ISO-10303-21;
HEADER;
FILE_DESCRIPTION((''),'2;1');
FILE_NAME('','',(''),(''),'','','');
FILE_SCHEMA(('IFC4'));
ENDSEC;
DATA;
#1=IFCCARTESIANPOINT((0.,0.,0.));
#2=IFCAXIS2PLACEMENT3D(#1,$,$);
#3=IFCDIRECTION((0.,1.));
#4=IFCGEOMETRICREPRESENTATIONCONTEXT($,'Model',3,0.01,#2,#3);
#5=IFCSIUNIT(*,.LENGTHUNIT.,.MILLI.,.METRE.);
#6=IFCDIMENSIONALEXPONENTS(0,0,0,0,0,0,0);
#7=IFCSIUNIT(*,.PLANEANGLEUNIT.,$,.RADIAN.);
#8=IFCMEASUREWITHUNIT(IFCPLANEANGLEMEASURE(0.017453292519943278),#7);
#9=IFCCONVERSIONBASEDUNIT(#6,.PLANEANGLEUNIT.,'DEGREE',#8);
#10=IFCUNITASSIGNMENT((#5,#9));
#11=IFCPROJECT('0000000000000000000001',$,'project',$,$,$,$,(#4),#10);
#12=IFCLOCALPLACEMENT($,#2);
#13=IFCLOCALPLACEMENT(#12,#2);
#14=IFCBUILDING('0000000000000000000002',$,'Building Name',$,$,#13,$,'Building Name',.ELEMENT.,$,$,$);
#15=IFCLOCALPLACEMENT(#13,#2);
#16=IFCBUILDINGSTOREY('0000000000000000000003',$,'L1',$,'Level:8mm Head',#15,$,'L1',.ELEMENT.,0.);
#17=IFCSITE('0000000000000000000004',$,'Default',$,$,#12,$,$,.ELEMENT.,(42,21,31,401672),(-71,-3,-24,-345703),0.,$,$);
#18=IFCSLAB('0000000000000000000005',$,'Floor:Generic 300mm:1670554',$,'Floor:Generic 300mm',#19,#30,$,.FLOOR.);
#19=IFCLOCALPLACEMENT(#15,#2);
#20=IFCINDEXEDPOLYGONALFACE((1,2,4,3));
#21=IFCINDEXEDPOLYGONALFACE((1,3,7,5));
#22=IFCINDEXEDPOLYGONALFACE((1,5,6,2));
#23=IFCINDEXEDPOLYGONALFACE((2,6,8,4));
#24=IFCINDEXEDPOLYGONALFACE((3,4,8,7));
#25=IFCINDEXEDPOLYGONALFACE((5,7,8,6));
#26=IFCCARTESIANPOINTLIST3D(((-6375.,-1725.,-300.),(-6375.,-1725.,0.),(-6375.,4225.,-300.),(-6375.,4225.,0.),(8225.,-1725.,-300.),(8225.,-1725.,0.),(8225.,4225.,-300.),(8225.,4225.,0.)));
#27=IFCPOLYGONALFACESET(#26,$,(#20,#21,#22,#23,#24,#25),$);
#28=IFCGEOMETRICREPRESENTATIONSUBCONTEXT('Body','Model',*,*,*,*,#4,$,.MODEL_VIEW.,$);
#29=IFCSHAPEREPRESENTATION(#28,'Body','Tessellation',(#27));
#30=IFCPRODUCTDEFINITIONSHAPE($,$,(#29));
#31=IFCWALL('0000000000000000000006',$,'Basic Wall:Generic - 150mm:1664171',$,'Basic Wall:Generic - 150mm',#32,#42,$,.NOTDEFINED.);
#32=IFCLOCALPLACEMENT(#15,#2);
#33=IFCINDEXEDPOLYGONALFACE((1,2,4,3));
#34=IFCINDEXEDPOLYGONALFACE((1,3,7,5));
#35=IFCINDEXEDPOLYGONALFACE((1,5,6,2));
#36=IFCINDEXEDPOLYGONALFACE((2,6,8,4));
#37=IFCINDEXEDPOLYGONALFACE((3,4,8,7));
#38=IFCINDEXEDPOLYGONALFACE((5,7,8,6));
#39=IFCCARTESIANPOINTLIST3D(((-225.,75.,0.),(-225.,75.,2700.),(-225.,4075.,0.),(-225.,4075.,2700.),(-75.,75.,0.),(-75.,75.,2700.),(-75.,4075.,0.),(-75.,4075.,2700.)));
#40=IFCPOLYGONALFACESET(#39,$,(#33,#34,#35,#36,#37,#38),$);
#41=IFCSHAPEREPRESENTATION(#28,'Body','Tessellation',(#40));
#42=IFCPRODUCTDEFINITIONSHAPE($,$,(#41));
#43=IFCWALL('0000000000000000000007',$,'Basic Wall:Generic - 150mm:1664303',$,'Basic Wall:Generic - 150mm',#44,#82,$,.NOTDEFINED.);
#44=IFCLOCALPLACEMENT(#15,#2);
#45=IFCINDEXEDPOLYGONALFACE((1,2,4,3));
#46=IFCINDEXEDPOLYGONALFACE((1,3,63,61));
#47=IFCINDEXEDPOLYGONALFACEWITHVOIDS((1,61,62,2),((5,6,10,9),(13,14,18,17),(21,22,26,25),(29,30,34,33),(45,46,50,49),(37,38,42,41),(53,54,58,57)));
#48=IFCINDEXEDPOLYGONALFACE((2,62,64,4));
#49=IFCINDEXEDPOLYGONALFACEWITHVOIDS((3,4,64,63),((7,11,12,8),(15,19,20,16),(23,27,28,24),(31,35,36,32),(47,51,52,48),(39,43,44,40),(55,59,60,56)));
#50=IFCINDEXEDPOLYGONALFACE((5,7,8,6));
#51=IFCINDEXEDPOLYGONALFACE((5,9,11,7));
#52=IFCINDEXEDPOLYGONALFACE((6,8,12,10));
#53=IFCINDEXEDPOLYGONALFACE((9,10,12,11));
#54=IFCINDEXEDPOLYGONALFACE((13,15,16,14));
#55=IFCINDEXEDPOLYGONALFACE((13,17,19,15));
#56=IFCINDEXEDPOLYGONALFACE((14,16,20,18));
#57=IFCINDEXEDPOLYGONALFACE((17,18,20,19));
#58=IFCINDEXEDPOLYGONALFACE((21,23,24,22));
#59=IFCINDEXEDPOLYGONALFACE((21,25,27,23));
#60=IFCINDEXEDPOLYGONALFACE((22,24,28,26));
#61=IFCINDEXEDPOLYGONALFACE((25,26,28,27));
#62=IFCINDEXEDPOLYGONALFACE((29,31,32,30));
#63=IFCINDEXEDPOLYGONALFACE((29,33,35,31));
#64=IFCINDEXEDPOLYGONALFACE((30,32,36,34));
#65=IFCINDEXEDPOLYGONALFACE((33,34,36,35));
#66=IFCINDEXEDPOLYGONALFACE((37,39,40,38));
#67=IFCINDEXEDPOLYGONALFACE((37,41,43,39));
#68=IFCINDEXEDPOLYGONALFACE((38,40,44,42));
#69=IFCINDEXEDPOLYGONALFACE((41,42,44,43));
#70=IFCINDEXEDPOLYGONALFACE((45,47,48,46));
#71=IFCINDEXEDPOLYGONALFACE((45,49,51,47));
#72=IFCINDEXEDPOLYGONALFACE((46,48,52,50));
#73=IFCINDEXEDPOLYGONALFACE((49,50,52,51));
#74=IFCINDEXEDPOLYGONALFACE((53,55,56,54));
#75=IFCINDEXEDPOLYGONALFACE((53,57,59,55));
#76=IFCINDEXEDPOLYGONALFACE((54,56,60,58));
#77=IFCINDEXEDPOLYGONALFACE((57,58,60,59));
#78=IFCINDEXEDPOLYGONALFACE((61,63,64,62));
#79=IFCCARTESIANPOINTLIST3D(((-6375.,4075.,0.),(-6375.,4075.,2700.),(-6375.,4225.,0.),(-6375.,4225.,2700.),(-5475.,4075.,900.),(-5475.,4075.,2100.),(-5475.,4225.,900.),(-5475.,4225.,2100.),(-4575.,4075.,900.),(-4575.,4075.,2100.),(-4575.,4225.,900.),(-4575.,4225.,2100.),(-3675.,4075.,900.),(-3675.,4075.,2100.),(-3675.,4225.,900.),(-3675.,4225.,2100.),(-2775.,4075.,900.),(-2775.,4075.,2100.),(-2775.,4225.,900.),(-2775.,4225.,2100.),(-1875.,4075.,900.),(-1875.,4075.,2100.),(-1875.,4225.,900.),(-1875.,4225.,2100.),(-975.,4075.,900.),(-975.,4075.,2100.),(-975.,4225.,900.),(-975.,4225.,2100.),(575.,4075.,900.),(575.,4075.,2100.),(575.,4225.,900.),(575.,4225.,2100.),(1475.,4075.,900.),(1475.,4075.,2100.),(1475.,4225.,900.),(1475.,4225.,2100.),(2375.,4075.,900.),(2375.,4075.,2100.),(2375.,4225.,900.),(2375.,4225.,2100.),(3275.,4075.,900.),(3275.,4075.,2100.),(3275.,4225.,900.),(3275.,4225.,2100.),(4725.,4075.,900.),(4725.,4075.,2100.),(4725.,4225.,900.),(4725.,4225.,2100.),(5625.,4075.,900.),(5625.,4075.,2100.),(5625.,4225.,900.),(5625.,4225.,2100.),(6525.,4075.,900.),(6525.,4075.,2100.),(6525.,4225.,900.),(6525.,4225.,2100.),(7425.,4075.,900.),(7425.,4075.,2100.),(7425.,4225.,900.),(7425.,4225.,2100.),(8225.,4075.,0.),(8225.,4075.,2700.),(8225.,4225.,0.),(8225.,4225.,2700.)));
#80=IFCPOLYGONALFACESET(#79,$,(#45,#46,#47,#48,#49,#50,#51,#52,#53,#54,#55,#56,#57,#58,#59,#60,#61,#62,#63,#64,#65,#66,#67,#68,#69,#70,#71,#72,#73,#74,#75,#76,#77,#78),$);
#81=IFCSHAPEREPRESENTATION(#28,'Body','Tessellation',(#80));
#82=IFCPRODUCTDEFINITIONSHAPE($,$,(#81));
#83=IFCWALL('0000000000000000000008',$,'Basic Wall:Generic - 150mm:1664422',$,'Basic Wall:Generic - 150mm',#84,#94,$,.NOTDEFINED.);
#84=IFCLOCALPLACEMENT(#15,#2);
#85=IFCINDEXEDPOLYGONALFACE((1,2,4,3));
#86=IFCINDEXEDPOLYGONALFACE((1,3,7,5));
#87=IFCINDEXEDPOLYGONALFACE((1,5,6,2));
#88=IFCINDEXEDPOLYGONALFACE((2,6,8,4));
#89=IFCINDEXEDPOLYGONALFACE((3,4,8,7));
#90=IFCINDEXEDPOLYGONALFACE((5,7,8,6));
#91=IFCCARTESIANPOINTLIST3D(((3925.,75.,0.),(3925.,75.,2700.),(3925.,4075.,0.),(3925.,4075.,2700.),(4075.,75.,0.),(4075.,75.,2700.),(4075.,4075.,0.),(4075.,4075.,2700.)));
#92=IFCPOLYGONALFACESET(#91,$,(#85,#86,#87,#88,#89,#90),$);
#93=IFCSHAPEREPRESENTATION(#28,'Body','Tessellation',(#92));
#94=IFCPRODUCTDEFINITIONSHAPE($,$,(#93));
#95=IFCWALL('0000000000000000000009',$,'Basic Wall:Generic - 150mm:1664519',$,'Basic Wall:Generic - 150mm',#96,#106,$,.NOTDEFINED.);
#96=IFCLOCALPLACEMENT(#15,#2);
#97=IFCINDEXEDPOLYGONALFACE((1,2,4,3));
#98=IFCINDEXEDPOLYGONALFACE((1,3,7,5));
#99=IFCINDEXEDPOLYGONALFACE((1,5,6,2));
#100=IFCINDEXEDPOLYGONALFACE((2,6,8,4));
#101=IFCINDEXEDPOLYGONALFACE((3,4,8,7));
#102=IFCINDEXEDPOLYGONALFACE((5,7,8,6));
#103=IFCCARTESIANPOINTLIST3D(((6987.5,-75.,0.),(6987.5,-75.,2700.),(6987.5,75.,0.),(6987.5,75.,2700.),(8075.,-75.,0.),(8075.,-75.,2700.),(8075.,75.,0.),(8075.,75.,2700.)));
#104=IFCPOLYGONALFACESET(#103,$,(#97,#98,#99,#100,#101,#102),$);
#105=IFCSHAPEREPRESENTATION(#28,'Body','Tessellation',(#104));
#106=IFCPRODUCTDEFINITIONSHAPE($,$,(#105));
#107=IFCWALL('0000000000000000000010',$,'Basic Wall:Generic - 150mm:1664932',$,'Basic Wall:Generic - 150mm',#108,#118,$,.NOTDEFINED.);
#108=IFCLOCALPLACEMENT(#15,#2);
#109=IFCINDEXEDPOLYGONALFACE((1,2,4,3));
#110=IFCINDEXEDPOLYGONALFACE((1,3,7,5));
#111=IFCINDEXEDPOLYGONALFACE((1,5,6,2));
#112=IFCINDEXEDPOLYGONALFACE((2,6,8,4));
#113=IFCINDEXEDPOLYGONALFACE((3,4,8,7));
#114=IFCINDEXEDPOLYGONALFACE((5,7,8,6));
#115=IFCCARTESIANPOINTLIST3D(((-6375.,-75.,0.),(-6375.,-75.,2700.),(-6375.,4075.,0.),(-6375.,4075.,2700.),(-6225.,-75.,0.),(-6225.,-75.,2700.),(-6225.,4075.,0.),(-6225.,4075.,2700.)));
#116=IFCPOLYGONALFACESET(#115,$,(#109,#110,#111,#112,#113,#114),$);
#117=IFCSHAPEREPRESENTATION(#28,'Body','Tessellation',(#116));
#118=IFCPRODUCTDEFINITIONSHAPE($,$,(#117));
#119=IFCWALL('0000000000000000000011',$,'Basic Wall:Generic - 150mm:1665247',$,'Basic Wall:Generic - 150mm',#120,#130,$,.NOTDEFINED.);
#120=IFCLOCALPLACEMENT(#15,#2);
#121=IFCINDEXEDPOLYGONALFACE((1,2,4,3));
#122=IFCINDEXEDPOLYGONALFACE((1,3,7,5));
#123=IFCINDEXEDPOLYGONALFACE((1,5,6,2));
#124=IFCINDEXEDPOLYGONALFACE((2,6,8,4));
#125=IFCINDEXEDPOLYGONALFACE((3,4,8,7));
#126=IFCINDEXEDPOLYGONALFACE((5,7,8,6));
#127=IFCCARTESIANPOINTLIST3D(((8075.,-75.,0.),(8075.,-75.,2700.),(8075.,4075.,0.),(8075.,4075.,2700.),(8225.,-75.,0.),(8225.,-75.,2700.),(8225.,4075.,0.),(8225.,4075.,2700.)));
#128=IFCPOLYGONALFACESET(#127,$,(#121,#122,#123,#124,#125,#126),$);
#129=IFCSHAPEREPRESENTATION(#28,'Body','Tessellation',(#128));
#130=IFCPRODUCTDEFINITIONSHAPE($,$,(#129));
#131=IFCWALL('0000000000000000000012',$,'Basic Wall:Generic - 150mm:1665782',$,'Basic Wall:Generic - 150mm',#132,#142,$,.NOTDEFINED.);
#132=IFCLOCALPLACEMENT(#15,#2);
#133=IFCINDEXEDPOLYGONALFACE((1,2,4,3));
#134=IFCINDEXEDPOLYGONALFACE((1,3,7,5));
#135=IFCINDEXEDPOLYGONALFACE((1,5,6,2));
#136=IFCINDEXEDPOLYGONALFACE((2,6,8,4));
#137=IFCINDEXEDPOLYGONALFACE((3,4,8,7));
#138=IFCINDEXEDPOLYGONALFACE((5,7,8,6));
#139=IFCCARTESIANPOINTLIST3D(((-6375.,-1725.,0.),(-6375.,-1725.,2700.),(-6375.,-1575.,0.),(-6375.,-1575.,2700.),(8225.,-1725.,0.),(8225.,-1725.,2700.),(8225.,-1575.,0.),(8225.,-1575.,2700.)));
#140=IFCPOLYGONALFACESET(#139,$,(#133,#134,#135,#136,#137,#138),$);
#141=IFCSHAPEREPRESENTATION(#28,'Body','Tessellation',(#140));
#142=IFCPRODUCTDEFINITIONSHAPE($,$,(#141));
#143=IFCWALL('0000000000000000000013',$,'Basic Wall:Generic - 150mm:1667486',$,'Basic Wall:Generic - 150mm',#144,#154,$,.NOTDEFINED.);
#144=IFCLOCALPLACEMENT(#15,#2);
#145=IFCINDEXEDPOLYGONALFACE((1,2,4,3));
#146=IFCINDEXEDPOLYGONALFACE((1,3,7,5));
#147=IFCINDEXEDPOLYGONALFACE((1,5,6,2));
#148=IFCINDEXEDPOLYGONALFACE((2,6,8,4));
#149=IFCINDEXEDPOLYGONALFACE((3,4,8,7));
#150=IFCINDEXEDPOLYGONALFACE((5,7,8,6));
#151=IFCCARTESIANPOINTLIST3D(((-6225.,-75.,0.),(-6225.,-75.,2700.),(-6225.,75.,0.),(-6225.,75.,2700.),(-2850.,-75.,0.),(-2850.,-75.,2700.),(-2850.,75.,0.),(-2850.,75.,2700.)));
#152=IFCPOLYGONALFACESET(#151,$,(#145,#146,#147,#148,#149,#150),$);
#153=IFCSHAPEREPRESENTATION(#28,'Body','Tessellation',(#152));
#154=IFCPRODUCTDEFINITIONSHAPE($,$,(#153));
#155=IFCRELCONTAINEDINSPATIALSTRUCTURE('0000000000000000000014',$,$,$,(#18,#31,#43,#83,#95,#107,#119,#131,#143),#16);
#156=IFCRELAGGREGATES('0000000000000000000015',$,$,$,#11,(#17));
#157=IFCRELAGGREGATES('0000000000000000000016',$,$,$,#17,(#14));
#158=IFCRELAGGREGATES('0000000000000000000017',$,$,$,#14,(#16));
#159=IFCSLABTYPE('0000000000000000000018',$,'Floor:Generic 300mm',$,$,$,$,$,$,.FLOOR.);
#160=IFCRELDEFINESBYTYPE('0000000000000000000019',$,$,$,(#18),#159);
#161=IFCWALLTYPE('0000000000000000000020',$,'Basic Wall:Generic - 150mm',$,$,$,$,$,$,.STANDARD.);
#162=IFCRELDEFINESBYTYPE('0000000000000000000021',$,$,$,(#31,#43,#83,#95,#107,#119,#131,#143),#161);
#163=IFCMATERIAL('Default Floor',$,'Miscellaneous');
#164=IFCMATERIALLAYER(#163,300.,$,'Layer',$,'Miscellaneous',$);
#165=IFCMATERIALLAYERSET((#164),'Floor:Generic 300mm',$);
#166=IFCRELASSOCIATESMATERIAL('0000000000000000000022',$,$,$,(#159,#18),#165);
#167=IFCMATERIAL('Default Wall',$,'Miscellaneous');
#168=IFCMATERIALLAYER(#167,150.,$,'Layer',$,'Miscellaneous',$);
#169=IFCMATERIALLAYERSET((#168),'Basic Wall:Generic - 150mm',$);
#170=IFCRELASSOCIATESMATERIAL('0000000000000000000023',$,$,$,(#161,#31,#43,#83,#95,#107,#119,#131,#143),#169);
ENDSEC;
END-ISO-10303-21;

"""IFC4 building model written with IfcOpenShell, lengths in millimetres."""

from ifc_helpers import new_model, entity, si_unit, converted_unit, direction, frame, frame_2d, origin, origin_2d_with_axis, place, context, subcontext, project, spatial, rectangle, extrude, material, layer, layer_set, layer_usage, type_object, element, save


model = new_model("IFC4")

# Units and contexts
model_context = context("Model", 3, precision=0.01, world=origin(), true_north=direction((0.0, 1.0)))
body_context = subcontext(model_context, "Body", "Model", "MODEL_VIEW")
ifc_project = project(units=[si_unit("LENGTHUNIT", "METRE", prefix="MILLI"), converted_unit("PLANEANGLEUNIT", "DEGREE", entity("IfcPlaneAngleMeasure", 0.017453292519943278), si_unit("PLANEANGLEUNIT", "RADIAN"), dimensions=[0, 0, 0, 0, 0, 0, 0])], contexts=[model_context])

# Site, building, storey
site_placement = place(None, origin())
site = spatial("IfcSite", under=ifc_project, at=site_placement, Name="Default", CompositionType="ELEMENT", RefLatitude=(42, 21, 31, 401672), RefLongitude=(-71, -3, -24, -345703), RefElevation=0.0)
building_placement = place(site_placement, origin())
building = spatial("IfcBuilding", under=site, at=building_placement, Name="Building Name", LongName="Building Name", CompositionType="ELEMENT")
storey_placement = place(building_placement, origin())
storey = spatial("IfcBuildingStorey", under=building, at=storey_placement, Name="L1", ObjectType="Level:8mm Head", LongName="L1", CompositionType="ELEMENT", Elevation=0.0)

# Slab
ifc_material_1 = material(Name="Default Floor", Category="Miscellaneous")
ifc_layer_1 = layer(ifc_material_1, 300.0, Name="Layer", Category="Miscellaneous")
ifc_layer_set_1 = layer_set([ifc_layer_1], Name="Floor:Generic 300mm")
ifc_layer_usage_1 = layer_usage(ifc_layer_set_1, "AXIS3", "POSITIVE", 0.0)
slab_type = type_object("IfcSlabType", Name="Floor:Generic 300mm", PredefinedType="FLOOR", material=ifc_layer_set_1)
slab_placement = place(storey_placement, origin())
element("IfcSlab", 1, at=slab_placement, inside=storey, type_object=slab_type, material=ifc_layer_usage_1, Name="Floor:Generic 300mm:1670554", ObjectType="Floor:Generic 300mm", PredefinedType="FLOOR", context=body_context, shape_type="SweptSolid", body=[
    extrude(rectangle(XDim=5950.0, YDim=14600.0, at=origin_2d_with_axis()), frame((925.0, 1250.0, 0.0), z_axis=(0.0, 0.0, -1.0), x_axis=(0.0, 1.0, 0.0)), (0.0, 0.0, 1.0), 300.0),
])

# Wall
ifc_material_2 = material(Name="Default Wall", Category="Miscellaneous")
ifc_layer_2 = layer(ifc_material_2, 150.0, Name="Layer", Category="Miscellaneous")
ifc_layer_set_2 = layer_set([ifc_layer_2], Name="Basic Wall:Generic - 150mm")
ifc_layer_usage_2 = layer_usage(ifc_layer_set_2, "AXIS2", "NEGATIVE", 75.0)
wall_type = type_object("IfcWallType", Name="Basic Wall:Generic - 150mm", PredefinedType="STANDARD", material=ifc_layer_set_2)
wall_1_placement = place(storey_placement, frame((-150.0, 75.0, 0.0), z_axis=(0.0, 0.0, 1.0), x_axis=(0.0, 1.0, 0.0)))
element("IfcWall", 2, at=wall_1_placement, inside=storey, type_object=wall_type, material=ifc_layer_usage_2, Name="Basic Wall:Generic - 150mm:1664171", ObjectType="Basic Wall:Generic - 150mm", PredefinedType="NOTDEFINED", context=body_context, shape_type="SweptSolid", body=[
    extrude(rectangle(XDim=4000.0, YDim=150.0, at=frame_2d((2000.0, 0.0), x_axis=(-1.0, 0.0))), origin(), (0.0, 0.0, 1.0), 2700.0),
])

# Wall, openings
ifc_layer_usage_3 = layer_usage(ifc_layer_set_2, "AXIS2", "NEGATIVE", 75.0)
wall_2_placement = place(storey_placement, frame((-6375.0, 4150.0, 0.0)))
wall_2 = element("IfcWall", 3, at=wall_2_placement, inside=storey, type_object=wall_type, material=ifc_layer_usage_3, Name="Basic Wall:Generic - 150mm:1664303", ObjectType="Basic Wall:Generic - 150mm", PredefinedType="NOTDEFINED", context=body_context, shape_type="SweptSolid", body=[
    extrude(rectangle(XDim=14600.0, YDim=150.0, at=frame_2d((7300.0, 0.0), x_axis=(-1.0, 0.0))), origin(), (0.0, 0.0, 1.0), 2700.0),
])
opening_1_placement = place(wall_2_placement, frame((8750.0, -75.0, 900.0)))
element("IfcOpeningElement", 4, at=opening_1_placement, cuts=wall_2, PredefinedType="OPENING", context=body_context, shape_type="SweptSolid", body=[
    extrude(rectangle(XDim=1200.0, YDim=900.0, at=frame_2d((600.0, 450.0), x_axis=(-1.0, 0.0))), frame((0.0, 0.0, 0.0), z_axis=(0.0, 1.0, 0.0), x_axis=(0.0, 0.0, 1.0)), (0.0, 0.0, 1.0), 150.0),
])
opening_2_placement = place(wall_2_placement, frame((6950.0, -75.0, 900.0)))
element("IfcOpeningElement", 5, at=opening_2_placement, cuts=wall_2, PredefinedType="OPENING", context=body_context, shape_type="SweptSolid", body=[
    extrude(rectangle(XDim=1200.0, YDim=900.0, at=frame_2d((600.0, 450.0), x_axis=(-1.0, 0.0))), frame((0.0, 0.0, 0.0), z_axis=(0.0, 1.0, 0.0), x_axis=(0.0, 0.0, 1.0)), (0.0, 0.0, 1.0), 150.0),
])
opening_3_placement = place(wall_2_placement, frame((4500.0, -75.0, 900.0)))
element("IfcOpeningElement", 6, at=opening_3_placement, cuts=wall_2, PredefinedType="OPENING", context=body_context, shape_type="SweptSolid", body=[
    extrude(rectangle(XDim=1200.0, YDim=900.0, at=frame_2d((600.0, 450.0), x_axis=(-1.0, 0.0))), frame((0.0, 0.0, 0.0), z_axis=(0.0, 1.0, 0.0), x_axis=(0.0, 0.0, 1.0)), (0.0, 0.0, 1.0), 150.0),
])
opening_4_placement = place(wall_2_placement, frame((2700.0, -75.0, 900.0)))
element("IfcOpeningElement", 7, at=opening_4_placement, cuts=wall_2, PredefinedType="OPENING", context=body_context, shape_type="SweptSolid", body=[
    extrude(rectangle(XDim=1200.0, YDim=900.0, at=frame_2d((600.0, 450.0), x_axis=(-1.0, 0.0))), frame((0.0, 0.0, 0.0), z_axis=(0.0, 1.0, 0.0), x_axis=(0.0, 0.0, 1.0)), (0.0, 0.0, 1.0), 150.0),
])
opening_5_placement = place(wall_2_placement, frame((900.0, -75.0, 900.0)))
element("IfcOpeningElement", 8, at=opening_5_placement, cuts=wall_2, PredefinedType="OPENING", context=body_context, shape_type="SweptSolid", body=[
    extrude(rectangle(XDim=1200.0, YDim=900.0, at=frame_2d((600.0, 450.0), x_axis=(-1.0, 0.0))), frame((0.0, 0.0, 0.0), z_axis=(0.0, 1.0, 0.0), x_axis=(0.0, 0.0, 1.0)), (0.0, 0.0, 1.0), 150.0),
])
opening_6_placement = place(wall_2_placement, frame((11100.0, -75.0, 900.0)))
element("IfcOpeningElement", 9, at=opening_6_placement, cuts=wall_2, PredefinedType="OPENING", context=body_context, shape_type="SweptSolid", body=[
    extrude(rectangle(XDim=1200.0, YDim=900.0, at=frame_2d((600.0, 450.0), x_axis=(-1.0, 0.0))), frame((0.0, 0.0, 0.0), z_axis=(0.0, 1.0, 0.0), x_axis=(0.0, 0.0, 1.0)), (0.0, 0.0, 1.0), 150.0),
])
opening_7_placement = place(wall_2_placement, frame((12900.0, -75.0, 900.0)))
element("IfcOpeningElement", 10, at=opening_7_placement, cuts=wall_2, PredefinedType="OPENING", context=body_context, shape_type="SweptSolid", body=[
    extrude(rectangle(XDim=1200.0, YDim=900.0, at=frame_2d((600.0, 450.0), x_axis=(-1.0, 0.0))), frame((0.0, 0.0, 0.0), z_axis=(0.0, 1.0, 0.0), x_axis=(0.0, 0.0, 1.0)), (0.0, 0.0, 1.0), 150.0),
])

# Walls
ifc_layer_usage_4 = layer_usage(ifc_layer_set_2, "AXIS2", "NEGATIVE", 75.0)
wall_3_placement = place(storey_placement, frame((4000.0, 4075.0, 0.0), z_axis=(0.0, 0.0, 1.0), x_axis=(0.0, -1.0, 0.0)))
element("IfcWall", 11, at=wall_3_placement, inside=storey, type_object=wall_type, material=ifc_layer_usage_4, Name="Basic Wall:Generic - 150mm:1664422", ObjectType="Basic Wall:Generic - 150mm", PredefinedType="NOTDEFINED", context=body_context, shape_type="SweptSolid", body=[
    extrude(rectangle(XDim=4000.0, YDim=150.0, at=frame_2d((2000.0, 0.0), x_axis=(-1.0, 0.0))), origin(), (0.0, 0.0, 1.0), 2700.0),
])
ifc_layer_usage_5 = layer_usage(ifc_layer_set_2, "AXIS2", "NEGATIVE", 75.0)
wall_4_placement = place(storey_placement, frame((8075.0, 0.0, 0.0), z_axis=(0.0, 0.0, 1.0), x_axis=(-1.0, 0.0, 0.0)))
element("IfcWall", 12, at=wall_4_placement, inside=storey, type_object=wall_type, material=ifc_layer_usage_5, Name="Basic Wall:Generic - 150mm:1664519", ObjectType="Basic Wall:Generic - 150mm", PredefinedType="NOTDEFINED", context=body_context, shape_type="SweptSolid", body=[
    extrude(rectangle(XDim=1087.5, YDim=150.0, at=frame_2d((543.7, 0.0), x_axis=(-1.0, 0.0))), origin(), (0.0, 0.0, 1.0), 2700.0),
])
ifc_layer_usage_6 = layer_usage(ifc_layer_set_2, "AXIS2", "NEGATIVE", 75.0)
wall_5_placement = place(storey_placement, frame((-6300.0, 4075.0, 0.0), z_axis=(0.0, 0.0, 1.0), x_axis=(0.0, -1.0, 0.0)))
element("IfcWall", 13, at=wall_5_placement, inside=storey, type_object=wall_type, material=ifc_layer_usage_6, Name="Basic Wall:Generic - 150mm:1664932", ObjectType="Basic Wall:Generic - 150mm", PredefinedType="NOTDEFINED", context=body_context, shape_type="SweptSolid", body=[
    extrude(rectangle(XDim=4150.0, YDim=150.0, at=frame_2d((2075.0, 0.0), x_axis=(-1.0, 0.0))), origin(), (0.0, 0.0, 1.0), 2700.0),
])
ifc_layer_usage_7 = layer_usage(ifc_layer_set_2, "AXIS2", "NEGATIVE", 75.0)
wall_6_placement = place(storey_placement, frame((8150.0, 4075.0, 0.0), z_axis=(0.0, 0.0, 1.0), x_axis=(0.0, -1.0, 0.0)))
element("IfcWall", 14, at=wall_6_placement, inside=storey, type_object=wall_type, material=ifc_layer_usage_7, Name="Basic Wall:Generic - 150mm:1665247", ObjectType="Basic Wall:Generic - 150mm", PredefinedType="NOTDEFINED", context=body_context, shape_type="SweptSolid", body=[
    extrude(rectangle(XDim=4150.0, YDim=150.0, at=frame_2d((2075.0, 0.0), x_axis=(-1.0, 0.0))), origin(), (0.0, 0.0, 1.0), 2700.0),
])
ifc_layer_usage_8 = layer_usage(ifc_layer_set_2, "AXIS2", "NEGATIVE", 75.0)
wall_7_placement = place(storey_placement, frame((8225.0, -1650.0, 0.0), z_axis=(0.0, 0.0, 1.0), x_axis=(-1.0, 0.0, 0.0)))
element("IfcWall", 15, at=wall_7_placement, inside=storey, type_object=wall_type, material=ifc_layer_usage_8, Name="Basic Wall:Generic - 150mm:1665782", ObjectType="Basic Wall:Generic - 150mm", PredefinedType="NOTDEFINED", context=body_context, shape_type="SweptSolid", body=[
    extrude(rectangle(XDim=14600.0, YDim=150.0, at=frame_2d((7300.0, 0.0), x_axis=(-1.0, 0.0))), origin(), (0.0, 0.0, 1.0), 2700.0),
])
ifc_layer_usage_9 = layer_usage(ifc_layer_set_2, "AXIS2", "NEGATIVE", 75.0)
wall_8_placement = place(storey_placement, frame((-2850.0, 0.0, 0.0), z_axis=(0.0, 0.0, 1.0), x_axis=(-1.0, 0.0, 0.0)))
element("IfcWall", 16, at=wall_8_placement, inside=storey, type_object=wall_type, material=ifc_layer_usage_9, Name="Basic Wall:Generic - 150mm:1667486", ObjectType="Basic Wall:Generic - 150mm", PredefinedType="NOTDEFINED", context=body_context, shape_type="SweptSolid", body=[
    extrude(rectangle(XDim=3375.0, YDim=150.0, at=frame_2d((1687.5, 0.0), x_axis=(-1.0, 0.0))), origin(), (0.0, 0.0, 1.0), 2700.0),
])

save(model, "model.ifc")
